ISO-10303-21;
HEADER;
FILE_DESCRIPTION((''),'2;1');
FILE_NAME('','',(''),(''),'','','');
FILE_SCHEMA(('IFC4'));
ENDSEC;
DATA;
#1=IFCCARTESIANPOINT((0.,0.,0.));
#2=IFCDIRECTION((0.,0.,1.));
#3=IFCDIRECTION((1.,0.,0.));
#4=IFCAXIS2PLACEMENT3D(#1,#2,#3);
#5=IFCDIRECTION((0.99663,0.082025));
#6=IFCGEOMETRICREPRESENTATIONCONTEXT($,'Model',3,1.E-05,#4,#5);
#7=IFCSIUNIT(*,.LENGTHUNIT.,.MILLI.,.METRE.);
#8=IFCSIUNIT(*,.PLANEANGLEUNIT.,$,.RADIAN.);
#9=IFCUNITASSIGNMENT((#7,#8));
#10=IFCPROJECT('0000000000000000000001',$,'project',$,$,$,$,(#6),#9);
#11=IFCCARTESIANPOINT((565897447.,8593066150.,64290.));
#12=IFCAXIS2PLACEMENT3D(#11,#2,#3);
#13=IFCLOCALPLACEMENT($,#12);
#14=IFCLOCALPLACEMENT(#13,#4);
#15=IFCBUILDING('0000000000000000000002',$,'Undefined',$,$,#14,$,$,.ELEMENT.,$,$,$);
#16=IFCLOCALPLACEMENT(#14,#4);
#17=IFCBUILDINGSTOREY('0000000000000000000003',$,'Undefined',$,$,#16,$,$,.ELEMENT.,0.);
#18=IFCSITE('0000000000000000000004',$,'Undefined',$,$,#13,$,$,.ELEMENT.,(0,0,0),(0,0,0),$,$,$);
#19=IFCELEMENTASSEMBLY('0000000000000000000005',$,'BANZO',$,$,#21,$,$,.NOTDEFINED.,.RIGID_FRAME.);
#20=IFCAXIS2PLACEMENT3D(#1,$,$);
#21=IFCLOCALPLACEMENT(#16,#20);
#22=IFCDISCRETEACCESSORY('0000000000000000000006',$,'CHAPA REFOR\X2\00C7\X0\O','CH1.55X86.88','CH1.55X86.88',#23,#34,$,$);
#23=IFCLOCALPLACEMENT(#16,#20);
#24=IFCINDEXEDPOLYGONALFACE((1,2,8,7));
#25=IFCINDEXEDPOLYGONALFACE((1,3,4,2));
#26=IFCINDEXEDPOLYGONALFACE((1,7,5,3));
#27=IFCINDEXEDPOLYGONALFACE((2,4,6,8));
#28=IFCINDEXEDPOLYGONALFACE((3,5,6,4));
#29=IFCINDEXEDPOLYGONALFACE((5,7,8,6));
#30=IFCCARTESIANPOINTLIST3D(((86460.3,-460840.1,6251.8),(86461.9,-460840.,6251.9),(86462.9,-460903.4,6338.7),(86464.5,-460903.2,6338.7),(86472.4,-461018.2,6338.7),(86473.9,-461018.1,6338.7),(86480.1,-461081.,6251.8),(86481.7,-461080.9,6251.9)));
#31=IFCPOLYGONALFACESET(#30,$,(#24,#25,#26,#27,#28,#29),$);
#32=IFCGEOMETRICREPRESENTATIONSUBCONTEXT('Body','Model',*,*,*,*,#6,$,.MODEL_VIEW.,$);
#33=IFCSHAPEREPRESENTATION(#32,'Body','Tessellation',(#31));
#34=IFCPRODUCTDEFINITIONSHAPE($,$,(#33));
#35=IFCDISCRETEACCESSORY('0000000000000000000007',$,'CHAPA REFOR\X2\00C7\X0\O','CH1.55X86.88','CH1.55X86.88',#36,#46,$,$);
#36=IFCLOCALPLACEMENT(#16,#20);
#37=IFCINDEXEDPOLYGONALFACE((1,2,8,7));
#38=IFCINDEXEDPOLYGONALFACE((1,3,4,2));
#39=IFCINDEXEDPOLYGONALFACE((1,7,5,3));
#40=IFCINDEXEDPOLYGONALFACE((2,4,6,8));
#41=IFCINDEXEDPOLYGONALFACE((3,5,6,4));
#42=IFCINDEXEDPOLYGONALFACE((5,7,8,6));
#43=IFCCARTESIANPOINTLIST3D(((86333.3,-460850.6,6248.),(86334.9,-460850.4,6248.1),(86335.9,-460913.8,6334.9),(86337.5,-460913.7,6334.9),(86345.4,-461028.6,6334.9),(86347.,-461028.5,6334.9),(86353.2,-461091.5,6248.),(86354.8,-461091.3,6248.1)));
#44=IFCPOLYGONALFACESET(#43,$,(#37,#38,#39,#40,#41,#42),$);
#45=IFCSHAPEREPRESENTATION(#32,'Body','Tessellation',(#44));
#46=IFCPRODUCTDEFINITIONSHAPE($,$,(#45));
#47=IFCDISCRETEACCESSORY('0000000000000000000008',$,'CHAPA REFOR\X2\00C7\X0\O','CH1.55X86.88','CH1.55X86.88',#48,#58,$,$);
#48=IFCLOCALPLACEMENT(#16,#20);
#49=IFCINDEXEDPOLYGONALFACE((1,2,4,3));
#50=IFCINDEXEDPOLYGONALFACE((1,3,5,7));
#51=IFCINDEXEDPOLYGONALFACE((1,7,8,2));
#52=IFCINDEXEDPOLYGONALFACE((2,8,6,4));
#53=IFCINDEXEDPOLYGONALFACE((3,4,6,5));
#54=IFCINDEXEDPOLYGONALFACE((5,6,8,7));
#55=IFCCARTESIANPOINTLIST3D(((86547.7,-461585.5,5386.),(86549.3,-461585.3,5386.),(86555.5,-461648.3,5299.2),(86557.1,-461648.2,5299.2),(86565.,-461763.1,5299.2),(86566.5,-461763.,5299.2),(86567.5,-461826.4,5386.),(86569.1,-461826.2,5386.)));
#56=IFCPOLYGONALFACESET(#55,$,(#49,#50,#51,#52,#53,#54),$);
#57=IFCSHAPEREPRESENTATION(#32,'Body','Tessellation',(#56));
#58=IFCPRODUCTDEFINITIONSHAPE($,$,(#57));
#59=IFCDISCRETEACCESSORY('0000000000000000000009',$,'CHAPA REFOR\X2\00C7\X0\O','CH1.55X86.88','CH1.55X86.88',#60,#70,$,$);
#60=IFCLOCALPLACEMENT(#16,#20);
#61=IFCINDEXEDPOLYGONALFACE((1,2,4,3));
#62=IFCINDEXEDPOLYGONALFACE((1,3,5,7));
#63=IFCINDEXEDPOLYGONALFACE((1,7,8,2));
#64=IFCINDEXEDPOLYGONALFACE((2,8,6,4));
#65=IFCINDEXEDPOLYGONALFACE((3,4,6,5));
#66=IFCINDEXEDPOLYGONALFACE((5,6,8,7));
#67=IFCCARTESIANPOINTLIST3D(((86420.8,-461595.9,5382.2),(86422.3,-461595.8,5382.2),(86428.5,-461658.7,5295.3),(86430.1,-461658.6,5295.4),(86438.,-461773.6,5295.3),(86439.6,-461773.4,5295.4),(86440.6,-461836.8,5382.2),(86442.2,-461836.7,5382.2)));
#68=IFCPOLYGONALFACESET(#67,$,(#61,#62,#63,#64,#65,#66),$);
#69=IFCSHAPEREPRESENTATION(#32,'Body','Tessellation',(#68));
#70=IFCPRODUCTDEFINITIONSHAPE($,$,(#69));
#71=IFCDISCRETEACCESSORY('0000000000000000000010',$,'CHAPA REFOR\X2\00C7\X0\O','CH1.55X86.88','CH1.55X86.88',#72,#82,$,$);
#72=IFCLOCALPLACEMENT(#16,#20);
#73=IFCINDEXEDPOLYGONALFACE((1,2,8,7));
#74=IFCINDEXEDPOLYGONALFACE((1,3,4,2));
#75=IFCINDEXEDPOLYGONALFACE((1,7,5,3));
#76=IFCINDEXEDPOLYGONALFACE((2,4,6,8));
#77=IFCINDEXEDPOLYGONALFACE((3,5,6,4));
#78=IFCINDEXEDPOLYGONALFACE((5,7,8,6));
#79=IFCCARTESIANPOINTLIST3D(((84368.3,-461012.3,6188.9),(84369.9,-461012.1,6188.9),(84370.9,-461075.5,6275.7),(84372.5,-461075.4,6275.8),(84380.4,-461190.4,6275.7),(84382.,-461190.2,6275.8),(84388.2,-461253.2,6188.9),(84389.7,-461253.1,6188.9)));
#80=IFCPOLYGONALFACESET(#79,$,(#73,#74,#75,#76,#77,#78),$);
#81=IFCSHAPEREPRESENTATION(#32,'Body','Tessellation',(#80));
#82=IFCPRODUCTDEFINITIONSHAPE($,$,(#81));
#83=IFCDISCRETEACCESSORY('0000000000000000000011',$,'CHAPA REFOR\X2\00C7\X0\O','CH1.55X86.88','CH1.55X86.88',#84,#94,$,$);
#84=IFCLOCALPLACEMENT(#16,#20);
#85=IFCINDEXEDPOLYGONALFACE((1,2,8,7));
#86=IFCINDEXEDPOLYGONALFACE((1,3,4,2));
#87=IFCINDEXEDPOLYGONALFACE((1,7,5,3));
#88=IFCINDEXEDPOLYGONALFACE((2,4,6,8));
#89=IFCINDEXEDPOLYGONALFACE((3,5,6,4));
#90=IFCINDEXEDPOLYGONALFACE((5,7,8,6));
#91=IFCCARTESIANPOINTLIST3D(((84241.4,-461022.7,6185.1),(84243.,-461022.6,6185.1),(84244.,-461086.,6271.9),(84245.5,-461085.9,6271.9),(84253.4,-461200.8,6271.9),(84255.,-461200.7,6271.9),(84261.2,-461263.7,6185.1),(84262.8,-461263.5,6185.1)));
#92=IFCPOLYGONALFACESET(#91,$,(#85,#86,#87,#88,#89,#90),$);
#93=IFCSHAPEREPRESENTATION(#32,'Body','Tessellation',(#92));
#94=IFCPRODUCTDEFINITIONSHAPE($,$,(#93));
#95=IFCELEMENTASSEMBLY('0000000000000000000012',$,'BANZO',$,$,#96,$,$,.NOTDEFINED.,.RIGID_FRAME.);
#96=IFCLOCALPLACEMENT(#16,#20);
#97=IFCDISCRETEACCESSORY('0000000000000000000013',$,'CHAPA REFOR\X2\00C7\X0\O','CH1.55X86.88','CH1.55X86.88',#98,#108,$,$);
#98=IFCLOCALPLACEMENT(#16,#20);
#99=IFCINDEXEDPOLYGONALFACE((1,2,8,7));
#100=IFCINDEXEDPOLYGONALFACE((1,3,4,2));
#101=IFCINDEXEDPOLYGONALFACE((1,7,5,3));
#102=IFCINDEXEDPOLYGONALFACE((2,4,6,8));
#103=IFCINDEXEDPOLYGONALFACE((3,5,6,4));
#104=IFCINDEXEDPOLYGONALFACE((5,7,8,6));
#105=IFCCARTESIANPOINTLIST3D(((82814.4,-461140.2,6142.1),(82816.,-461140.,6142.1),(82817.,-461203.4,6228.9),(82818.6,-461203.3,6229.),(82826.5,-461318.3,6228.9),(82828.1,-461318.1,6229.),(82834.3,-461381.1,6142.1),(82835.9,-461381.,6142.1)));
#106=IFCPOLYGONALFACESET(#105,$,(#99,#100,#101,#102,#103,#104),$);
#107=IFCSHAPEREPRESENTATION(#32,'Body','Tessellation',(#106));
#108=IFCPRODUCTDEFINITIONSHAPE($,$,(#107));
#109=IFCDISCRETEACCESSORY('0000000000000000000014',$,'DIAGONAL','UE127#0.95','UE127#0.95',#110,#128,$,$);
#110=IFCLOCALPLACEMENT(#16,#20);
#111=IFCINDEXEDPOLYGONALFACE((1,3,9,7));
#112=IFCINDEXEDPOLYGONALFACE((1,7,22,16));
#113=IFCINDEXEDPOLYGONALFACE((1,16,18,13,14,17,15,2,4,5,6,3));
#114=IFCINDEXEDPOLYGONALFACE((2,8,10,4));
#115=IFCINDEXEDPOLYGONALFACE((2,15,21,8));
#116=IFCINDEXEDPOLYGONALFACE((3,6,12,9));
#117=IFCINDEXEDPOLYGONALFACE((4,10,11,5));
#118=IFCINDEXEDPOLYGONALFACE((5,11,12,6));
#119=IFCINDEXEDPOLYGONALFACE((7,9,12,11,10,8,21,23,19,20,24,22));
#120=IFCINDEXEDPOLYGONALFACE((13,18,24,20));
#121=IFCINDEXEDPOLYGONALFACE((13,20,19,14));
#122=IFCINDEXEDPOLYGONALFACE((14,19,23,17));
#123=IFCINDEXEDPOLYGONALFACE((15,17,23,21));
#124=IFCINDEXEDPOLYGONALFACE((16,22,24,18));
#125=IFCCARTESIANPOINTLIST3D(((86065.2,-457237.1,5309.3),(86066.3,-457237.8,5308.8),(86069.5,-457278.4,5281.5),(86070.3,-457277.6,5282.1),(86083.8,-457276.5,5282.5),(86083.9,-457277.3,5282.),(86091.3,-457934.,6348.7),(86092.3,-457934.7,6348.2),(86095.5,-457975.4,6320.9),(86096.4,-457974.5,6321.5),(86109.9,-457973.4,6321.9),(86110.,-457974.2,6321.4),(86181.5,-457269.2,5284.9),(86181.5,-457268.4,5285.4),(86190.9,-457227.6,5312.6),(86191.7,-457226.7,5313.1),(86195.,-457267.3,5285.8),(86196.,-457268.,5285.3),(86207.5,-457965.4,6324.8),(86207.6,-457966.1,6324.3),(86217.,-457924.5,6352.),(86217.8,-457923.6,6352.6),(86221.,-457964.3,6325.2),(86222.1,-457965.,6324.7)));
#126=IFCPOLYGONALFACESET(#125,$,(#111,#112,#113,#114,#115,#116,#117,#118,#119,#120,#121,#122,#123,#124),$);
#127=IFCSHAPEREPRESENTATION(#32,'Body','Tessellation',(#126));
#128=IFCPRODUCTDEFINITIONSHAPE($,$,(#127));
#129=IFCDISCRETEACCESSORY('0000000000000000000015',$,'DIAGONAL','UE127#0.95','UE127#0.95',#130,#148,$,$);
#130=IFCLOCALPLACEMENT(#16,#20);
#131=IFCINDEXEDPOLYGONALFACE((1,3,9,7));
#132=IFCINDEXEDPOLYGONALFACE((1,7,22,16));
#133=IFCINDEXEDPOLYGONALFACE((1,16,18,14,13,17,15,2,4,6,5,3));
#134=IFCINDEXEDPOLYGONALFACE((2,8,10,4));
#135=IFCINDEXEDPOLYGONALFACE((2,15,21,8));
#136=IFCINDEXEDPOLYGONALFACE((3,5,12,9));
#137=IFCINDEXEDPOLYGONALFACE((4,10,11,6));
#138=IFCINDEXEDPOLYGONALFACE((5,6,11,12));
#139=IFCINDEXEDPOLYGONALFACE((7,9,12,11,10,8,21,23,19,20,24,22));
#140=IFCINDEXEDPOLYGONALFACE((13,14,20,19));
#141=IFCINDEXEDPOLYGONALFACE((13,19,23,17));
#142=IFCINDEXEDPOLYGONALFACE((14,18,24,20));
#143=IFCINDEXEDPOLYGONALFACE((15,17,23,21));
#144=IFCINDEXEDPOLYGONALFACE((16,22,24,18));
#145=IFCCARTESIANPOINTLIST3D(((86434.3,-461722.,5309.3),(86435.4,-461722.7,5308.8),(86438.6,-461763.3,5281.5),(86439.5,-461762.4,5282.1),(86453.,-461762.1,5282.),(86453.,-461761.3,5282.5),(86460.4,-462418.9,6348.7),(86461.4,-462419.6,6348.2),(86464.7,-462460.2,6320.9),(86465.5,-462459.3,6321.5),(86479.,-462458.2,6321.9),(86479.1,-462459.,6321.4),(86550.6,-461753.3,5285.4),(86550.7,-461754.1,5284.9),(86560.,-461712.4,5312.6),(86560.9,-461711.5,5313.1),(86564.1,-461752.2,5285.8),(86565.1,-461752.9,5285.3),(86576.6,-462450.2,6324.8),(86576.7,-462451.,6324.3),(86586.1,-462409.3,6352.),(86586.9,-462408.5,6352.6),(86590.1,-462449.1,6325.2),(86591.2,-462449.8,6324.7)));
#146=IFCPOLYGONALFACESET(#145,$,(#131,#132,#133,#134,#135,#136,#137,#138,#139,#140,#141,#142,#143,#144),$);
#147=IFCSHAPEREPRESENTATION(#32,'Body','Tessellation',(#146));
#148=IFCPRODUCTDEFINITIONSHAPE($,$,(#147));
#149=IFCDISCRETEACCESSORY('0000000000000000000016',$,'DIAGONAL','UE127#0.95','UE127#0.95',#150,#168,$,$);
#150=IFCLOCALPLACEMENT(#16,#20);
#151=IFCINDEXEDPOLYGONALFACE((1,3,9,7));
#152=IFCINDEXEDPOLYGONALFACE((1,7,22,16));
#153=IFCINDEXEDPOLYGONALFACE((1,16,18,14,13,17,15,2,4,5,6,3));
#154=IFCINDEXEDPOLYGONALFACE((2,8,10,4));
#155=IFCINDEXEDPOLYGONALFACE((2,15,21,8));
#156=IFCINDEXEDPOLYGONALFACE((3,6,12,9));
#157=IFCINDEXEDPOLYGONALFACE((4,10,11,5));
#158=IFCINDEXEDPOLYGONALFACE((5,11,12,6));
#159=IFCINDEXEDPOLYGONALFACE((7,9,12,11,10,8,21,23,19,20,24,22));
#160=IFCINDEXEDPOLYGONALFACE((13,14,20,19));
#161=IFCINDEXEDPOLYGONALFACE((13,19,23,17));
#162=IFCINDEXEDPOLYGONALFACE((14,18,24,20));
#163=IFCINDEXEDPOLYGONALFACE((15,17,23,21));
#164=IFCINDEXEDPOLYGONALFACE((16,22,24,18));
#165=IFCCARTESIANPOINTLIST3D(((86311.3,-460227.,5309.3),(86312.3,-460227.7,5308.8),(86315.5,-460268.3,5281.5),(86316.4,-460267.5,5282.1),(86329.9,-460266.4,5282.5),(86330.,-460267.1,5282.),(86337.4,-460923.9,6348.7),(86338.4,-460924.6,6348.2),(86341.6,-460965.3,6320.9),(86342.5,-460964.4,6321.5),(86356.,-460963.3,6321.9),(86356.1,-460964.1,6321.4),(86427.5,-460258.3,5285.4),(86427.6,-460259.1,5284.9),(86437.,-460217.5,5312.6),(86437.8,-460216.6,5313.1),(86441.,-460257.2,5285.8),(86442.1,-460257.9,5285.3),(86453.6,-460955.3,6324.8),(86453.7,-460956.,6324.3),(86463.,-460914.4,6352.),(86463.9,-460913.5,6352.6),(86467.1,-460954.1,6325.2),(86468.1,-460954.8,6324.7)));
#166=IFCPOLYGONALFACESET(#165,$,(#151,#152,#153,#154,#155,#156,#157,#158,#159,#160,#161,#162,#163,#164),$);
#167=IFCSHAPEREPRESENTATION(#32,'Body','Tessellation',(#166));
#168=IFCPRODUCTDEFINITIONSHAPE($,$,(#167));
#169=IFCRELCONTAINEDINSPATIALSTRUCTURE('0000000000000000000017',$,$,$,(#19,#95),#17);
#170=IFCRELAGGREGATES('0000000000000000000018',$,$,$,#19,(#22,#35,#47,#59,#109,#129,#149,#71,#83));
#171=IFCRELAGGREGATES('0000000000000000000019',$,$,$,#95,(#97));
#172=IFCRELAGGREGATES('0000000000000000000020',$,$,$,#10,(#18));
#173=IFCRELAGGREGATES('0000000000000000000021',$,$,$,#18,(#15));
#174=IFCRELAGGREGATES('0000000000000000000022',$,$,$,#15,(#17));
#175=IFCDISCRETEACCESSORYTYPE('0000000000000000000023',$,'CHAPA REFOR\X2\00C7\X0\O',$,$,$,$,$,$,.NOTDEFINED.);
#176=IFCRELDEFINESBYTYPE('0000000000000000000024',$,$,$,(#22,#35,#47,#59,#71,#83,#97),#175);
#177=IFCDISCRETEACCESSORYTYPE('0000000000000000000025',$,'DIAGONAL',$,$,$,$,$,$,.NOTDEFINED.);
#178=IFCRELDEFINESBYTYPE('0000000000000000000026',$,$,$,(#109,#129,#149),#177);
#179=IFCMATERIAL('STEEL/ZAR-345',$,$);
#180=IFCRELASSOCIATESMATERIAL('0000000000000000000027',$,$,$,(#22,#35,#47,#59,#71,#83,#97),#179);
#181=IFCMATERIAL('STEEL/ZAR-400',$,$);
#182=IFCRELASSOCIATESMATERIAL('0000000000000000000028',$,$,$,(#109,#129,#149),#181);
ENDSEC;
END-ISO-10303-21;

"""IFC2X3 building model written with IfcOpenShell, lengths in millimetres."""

from ifc_helpers import new_model, si_unit, direction, frame, frame_2d, origin_with_axes, place, context, subcontext, project, spatial, polyline, c_section, outline, extrude, material, type_object, element, aggregate, save


model = new_model("IFC2X3")

# Units and contexts
model_context = context("Model", 3, precision=1e-05, world=origin_with_axes(), true_north=direction((0.99663, 0.082025)))
body_context = subcontext(model_context, "Body", "Model", "MODEL_VIEW")
ifc_project = project(units=[si_unit("LENGTHUNIT", "METRE", prefix="MILLI"), si_unit("PLANEANGLEUNIT", "RADIAN")], contexts=[model_context])

# Site, building, storey
site_placement = place(None, frame((565897447.0, 8593066150.0, 64290.0), z_axis=(0.0, 0.0, 1.0), x_axis=(1.0, 0.0, 0.0)))
site = spatial("IfcSite", under=ifc_project, at=site_placement, Name="Undefined", CompositionType="ELEMENT", RefLatitude=(0, 0, 0), RefLongitude=(0, 0, 0))
building_placement = place(site_placement, origin_with_axes())
building = spatial("IfcBuilding", under=site, at=building_placement, Name="Undefined", CompositionType="ELEMENT")
storey_placement = place(building_placement, origin_with_axes())
storey = spatial("IfcBuildingStorey", under=building, at=storey_placement, Name="Undefined", CompositionType="ELEMENT", Elevation=0.0)

# Element assembly, discrete accessories
assembly_1_placement = place(storey_placement, origin_with_axes())
assembly_1 = element("IfcElementAssembly", 1, at=assembly_1_placement, inside=storey, Name="BANZO", AssemblyPlace="NOTDEFINED", PredefinedType="RIGID_FRAME")
ifc_material_1 = material(Name="STEEL/ZAR-345")
discrete_accessory_type_1 = type_object("IfcDiscreteAccessoryType", Name="CHAPA REFORÇO")
discrete_accessory_1_placement = place(assembly_1_placement, frame((86480.9, -461081.0, 6251.9), z_axis=(0.996182, 0.081989, 0.029987), x_axis=(-0.082025, 0.99663, 0.0)))
discrete_accessory_1 = element("IfcDiscreteAccessory", 2, at=discrete_accessory_1_placement, type_object=discrete_accessory_type_1, material=ifc_material_1, Name="CHAPA REFORÇO", Description="CH1.55X86.88", ObjectType="CH1.55X86.88", context=body_context, shape_type="SweptSolid", body=[
    extrude(outline(polyline([(0.0, 0.0), (241.7, 0.0), (178.5, 86.9), (63.3, 86.9), (0.0, 0.0)])), frame((0.0, 0.0, -0.8), z_axis=(0.0, 0.0, 1.0), x_axis=(1.0, 0.0, 0.0)), (0.0, 0.0, 1.0), 1.6),
])
discrete_accessory_2_placement = place(assembly_1_placement, frame((86354.0, -461091.4, 6248.0), z_axis=(0.996182, 0.081989, 0.029987), x_axis=(-0.082025, 0.99663, 0.0)))
discrete_accessory_2 = element("IfcDiscreteAccessory", 3, at=discrete_accessory_2_placement, type_object=discrete_accessory_type_1, material=ifc_material_1, Name="CHAPA REFORÇO", Description="CH1.55X86.88", ObjectType="CH1.55X86.88", context=body_context, shape_type="SweptSolid", body=[
    extrude(outline(polyline([(0.0, 0.0), (241.7, 0.0), (178.5, 86.9), (63.3, 86.9), (0.0, 0.0)])), frame((0.0, 0.0, -0.8), z_axis=(0.0, 0.0, 1.0), x_axis=(1.0, 0.0, 0.0)), (0.0, 0.0, 1.0), 1.6),
])
discrete_accessory_3_placement = place(assembly_1_placement, frame((86548.5, -461585.4, 5386.0), z_axis=(0.996182, 0.081989, 0.029987), x_axis=(0.082025, -0.99663, 0.0)))
discrete_accessory_3 = element("IfcDiscreteAccessory", 4, at=discrete_accessory_3_placement, type_object=discrete_accessory_type_1, material=ifc_material_1, Name="CHAPA REFORÇO", Description="CH1.55X86.88", ObjectType="CH1.55X86.88", context=body_context, shape_type="SweptSolid", body=[
    extrude(outline(polyline([(0.0, 0.0), (241.7, 0.0), (178.5, 86.9), (63.3, 86.9), (0.0, 0.0)])), frame((0.0, 0.0, -0.8), z_axis=(0.0, 0.0, 1.0), x_axis=(1.0, 0.0, 0.0)), (0.0, 0.0, 1.0), 1.6),
])
discrete_accessory_4_placement = place(assembly_1_placement, frame((86421.5, -461595.8, 5382.2), z_axis=(0.996182, 0.081989, 0.029987), x_axis=(0.082025, -0.99663, 0.0)))
discrete_accessory_4 = element("IfcDiscreteAccessory", 5, at=discrete_accessory_4_placement, type_object=discrete_accessory_type_1, material=ifc_material_1, Name="CHAPA REFORÇO", Description="CH1.55X86.88", ObjectType="CH1.55X86.88", context=body_context, shape_type="SweptSolid", body=[
    extrude(outline(polyline([(0.0, 0.0), (241.7, 0.0), (178.5, 86.9), (63.3, 86.9), (0.0, 0.0)])), frame((0.0, 0.0, -0.8), z_axis=(0.0, 0.0, 1.0), x_axis=(1.0, 0.0, 0.0)), (0.0, 0.0, 1.0), 1.6),
])
discrete_accessory_5_placement = place(assembly_1_placement, frame((84389.0, -461253.1, 6188.9), z_axis=(0.996182, 0.081989, 0.029987), x_axis=(-0.082025, 0.99663, 0.0)))
discrete_accessory_5 = element("IfcDiscreteAccessory", 6, at=discrete_accessory_5_placement, type_object=discrete_accessory_type_1, material=ifc_material_1, Name="CHAPA REFORÇO", Description="CH1.55X86.88", ObjectType="CH1.55X86.88", context=body_context, shape_type="SweptSolid", body=[
    extrude(outline(polyline([(0.0, 0.0), (241.7, 0.0), (178.5, 86.9), (63.3, 86.9), (0.0, 0.0)])), frame((0.0, 0.0, -0.8), z_axis=(0.0, 0.0, 1.0), x_axis=(1.0, 0.0, 0.0)), (0.0, 0.0, 1.0), 1.6),
])
discrete_accessory_6_placement = place(assembly_1_placement, frame((84262.0, -461263.6, 6185.1), z_axis=(0.996182, 0.081989, 0.029987), x_axis=(-0.082025, 0.99663, 0.0)))
discrete_accessory_6 = element("IfcDiscreteAccessory", 7, at=discrete_accessory_6_placement, type_object=discrete_accessory_type_1, material=ifc_material_1, Name="CHAPA REFORÇO", Description="CH1.55X86.88", ObjectType="CH1.55X86.88", context=body_context, shape_type="SweptSolid", body=[
    extrude(outline(polyline([(0.0, 0.0), (241.7, 0.0), (178.5, 86.9), (63.3, 86.9), (0.0, 0.0)])), frame((0.0, 0.0, -0.8), z_axis=(0.0, 0.0, 1.0), x_axis=(1.0, 0.0, 0.0)), (0.0, 0.0, 1.0), 1.6),
])

# Element assembly, discrete accessory
assembly_2_placement = place(storey_placement, origin_with_axes())
assembly_2 = element("IfcElementAssembly", 8, at=assembly_2_placement, inside=storey, Name="BANZO", AssemblyPlace="NOTDEFINED", PredefinedType="RIGID_FRAME")
discrete_accessory_7_placement = place(assembly_2_placement, frame((82835.1, -461381.0, 6142.1), z_axis=(0.996182, 0.081989, 0.029987), x_axis=(-0.082025, 0.99663, 0.0)))
discrete_accessory_7 = element("IfcDiscreteAccessory", 9, at=discrete_accessory_7_placement, type_object=discrete_accessory_type_1, material=ifc_material_1, Name="CHAPA REFORÇO", Description="CH1.55X86.88", ObjectType="CH1.55X86.88", context=body_context, shape_type="SweptSolid", body=[
    extrude(outline(polyline([(0.0, 0.0), (241.7, 0.0), (178.5, 86.9), (63.3, 86.9), (0.0, 0.0)])), frame((0.0, 0.0, -0.8), z_axis=(0.0, 0.0, 1.0), x_axis=(1.0, 0.0, 0.0)), (0.0, 0.0, 1.0), 1.6),
])

# Discrete accessories
ifc_material_2 = material(Name="STEEL/ZAR-400")
discrete_accessory_type_2 = type_object("IfcDiscreteAccessoryType", Name="DIAGONAL")
discrete_accessory_8_placement = place(assembly_1_placement, frame((86130.6, -457252.6, 5297.3), z_axis=(-0.996182, -0.081989, -0.029987), x_axis=(0.020829, -0.556784, 0.830396)))
discrete_accessory_8 = element("IfcDiscreteAccessory", 10, at=discrete_accessory_8_placement, type_object=discrete_accessory_type_2, material=ifc_material_2, Name="DIAGONAL", Description="UE127#0.95", ObjectType="UE127#0.95", context=body_context, shape_type="SweptSolid", body=[
    extrude(c_section(Depth=127.0, Width=50.0, WallThickness=0.9, Girth=14.5, at=frame_2d((0.0, 0.0), x_axis=(1.0, 0.0))), frame((1251.7, 0.0, 0.0), z_axis=(-1.0, 0.0, 0.0), x_axis=(0.0, -1.0, 0.0)), (0.0, 0.0, 1.0), 1251.7),
])
discrete_accessory_9_placement = place(assembly_1_placement, frame((86499.7, -461737.4, 5297.3), z_axis=(-0.996182, -0.081989, -0.029987), x_axis=(0.020829, -0.556784, 0.830396)))
discrete_accessory_9 = element("IfcDiscreteAccessory", 11, at=discrete_accessory_9_placement, type_object=discrete_accessory_type_2, material=ifc_material_2, Name="DIAGONAL", Description="UE127#0.95", ObjectType="UE127#0.95", context=body_context, shape_type="SweptSolid", body=[
    extrude(c_section(Depth=127.0, Width=50.0, WallThickness=0.9, Girth=14.5, at=frame_2d((0.0, 0.0), x_axis=(1.0, 0.0))), frame((1251.7, 0.0, 0.0), z_axis=(-1.0, 0.0, 0.0), x_axis=(0.0, -1.0, 0.0)), (0.0, 0.0, 1.0), 1251.7),
])
discrete_accessory_10_placement = place(assembly_1_placement, frame((86376.7, -460242.5, 5297.3), z_axis=(-0.996182, -0.081989, -0.029987), x_axis=(0.020829, -0.556784, 0.830396)))
discrete_accessory_10 = element("IfcDiscreteAccessory", 12, at=discrete_accessory_10_placement, type_object=discrete_accessory_type_2, material=ifc_material_2, Name="DIAGONAL", Description="UE127#0.95", ObjectType="UE127#0.95", context=body_context, shape_type="SweptSolid", body=[
    extrude(c_section(Depth=127.0, Width=50.0, WallThickness=0.9, Girth=14.5, at=frame_2d((0.0, 0.0), x_axis=(1.0, 0.0))), frame((1251.7, 0.0, 0.0), z_axis=(-1.0, 0.0, 0.0), x_axis=(0.0, -1.0, 0.0)), (0.0, 0.0, 1.0), 1251.7),
])
aggregate(assembly_1, [discrete_accessory_1, discrete_accessory_2, discrete_accessory_3, discrete_accessory_4, discrete_accessory_8, discrete_accessory_9, discrete_accessory_10, discrete_accessory_5, discrete_accessory_6])
aggregate(assembly_2, [discrete_accessory_7])

save(model, "model.ifc")
